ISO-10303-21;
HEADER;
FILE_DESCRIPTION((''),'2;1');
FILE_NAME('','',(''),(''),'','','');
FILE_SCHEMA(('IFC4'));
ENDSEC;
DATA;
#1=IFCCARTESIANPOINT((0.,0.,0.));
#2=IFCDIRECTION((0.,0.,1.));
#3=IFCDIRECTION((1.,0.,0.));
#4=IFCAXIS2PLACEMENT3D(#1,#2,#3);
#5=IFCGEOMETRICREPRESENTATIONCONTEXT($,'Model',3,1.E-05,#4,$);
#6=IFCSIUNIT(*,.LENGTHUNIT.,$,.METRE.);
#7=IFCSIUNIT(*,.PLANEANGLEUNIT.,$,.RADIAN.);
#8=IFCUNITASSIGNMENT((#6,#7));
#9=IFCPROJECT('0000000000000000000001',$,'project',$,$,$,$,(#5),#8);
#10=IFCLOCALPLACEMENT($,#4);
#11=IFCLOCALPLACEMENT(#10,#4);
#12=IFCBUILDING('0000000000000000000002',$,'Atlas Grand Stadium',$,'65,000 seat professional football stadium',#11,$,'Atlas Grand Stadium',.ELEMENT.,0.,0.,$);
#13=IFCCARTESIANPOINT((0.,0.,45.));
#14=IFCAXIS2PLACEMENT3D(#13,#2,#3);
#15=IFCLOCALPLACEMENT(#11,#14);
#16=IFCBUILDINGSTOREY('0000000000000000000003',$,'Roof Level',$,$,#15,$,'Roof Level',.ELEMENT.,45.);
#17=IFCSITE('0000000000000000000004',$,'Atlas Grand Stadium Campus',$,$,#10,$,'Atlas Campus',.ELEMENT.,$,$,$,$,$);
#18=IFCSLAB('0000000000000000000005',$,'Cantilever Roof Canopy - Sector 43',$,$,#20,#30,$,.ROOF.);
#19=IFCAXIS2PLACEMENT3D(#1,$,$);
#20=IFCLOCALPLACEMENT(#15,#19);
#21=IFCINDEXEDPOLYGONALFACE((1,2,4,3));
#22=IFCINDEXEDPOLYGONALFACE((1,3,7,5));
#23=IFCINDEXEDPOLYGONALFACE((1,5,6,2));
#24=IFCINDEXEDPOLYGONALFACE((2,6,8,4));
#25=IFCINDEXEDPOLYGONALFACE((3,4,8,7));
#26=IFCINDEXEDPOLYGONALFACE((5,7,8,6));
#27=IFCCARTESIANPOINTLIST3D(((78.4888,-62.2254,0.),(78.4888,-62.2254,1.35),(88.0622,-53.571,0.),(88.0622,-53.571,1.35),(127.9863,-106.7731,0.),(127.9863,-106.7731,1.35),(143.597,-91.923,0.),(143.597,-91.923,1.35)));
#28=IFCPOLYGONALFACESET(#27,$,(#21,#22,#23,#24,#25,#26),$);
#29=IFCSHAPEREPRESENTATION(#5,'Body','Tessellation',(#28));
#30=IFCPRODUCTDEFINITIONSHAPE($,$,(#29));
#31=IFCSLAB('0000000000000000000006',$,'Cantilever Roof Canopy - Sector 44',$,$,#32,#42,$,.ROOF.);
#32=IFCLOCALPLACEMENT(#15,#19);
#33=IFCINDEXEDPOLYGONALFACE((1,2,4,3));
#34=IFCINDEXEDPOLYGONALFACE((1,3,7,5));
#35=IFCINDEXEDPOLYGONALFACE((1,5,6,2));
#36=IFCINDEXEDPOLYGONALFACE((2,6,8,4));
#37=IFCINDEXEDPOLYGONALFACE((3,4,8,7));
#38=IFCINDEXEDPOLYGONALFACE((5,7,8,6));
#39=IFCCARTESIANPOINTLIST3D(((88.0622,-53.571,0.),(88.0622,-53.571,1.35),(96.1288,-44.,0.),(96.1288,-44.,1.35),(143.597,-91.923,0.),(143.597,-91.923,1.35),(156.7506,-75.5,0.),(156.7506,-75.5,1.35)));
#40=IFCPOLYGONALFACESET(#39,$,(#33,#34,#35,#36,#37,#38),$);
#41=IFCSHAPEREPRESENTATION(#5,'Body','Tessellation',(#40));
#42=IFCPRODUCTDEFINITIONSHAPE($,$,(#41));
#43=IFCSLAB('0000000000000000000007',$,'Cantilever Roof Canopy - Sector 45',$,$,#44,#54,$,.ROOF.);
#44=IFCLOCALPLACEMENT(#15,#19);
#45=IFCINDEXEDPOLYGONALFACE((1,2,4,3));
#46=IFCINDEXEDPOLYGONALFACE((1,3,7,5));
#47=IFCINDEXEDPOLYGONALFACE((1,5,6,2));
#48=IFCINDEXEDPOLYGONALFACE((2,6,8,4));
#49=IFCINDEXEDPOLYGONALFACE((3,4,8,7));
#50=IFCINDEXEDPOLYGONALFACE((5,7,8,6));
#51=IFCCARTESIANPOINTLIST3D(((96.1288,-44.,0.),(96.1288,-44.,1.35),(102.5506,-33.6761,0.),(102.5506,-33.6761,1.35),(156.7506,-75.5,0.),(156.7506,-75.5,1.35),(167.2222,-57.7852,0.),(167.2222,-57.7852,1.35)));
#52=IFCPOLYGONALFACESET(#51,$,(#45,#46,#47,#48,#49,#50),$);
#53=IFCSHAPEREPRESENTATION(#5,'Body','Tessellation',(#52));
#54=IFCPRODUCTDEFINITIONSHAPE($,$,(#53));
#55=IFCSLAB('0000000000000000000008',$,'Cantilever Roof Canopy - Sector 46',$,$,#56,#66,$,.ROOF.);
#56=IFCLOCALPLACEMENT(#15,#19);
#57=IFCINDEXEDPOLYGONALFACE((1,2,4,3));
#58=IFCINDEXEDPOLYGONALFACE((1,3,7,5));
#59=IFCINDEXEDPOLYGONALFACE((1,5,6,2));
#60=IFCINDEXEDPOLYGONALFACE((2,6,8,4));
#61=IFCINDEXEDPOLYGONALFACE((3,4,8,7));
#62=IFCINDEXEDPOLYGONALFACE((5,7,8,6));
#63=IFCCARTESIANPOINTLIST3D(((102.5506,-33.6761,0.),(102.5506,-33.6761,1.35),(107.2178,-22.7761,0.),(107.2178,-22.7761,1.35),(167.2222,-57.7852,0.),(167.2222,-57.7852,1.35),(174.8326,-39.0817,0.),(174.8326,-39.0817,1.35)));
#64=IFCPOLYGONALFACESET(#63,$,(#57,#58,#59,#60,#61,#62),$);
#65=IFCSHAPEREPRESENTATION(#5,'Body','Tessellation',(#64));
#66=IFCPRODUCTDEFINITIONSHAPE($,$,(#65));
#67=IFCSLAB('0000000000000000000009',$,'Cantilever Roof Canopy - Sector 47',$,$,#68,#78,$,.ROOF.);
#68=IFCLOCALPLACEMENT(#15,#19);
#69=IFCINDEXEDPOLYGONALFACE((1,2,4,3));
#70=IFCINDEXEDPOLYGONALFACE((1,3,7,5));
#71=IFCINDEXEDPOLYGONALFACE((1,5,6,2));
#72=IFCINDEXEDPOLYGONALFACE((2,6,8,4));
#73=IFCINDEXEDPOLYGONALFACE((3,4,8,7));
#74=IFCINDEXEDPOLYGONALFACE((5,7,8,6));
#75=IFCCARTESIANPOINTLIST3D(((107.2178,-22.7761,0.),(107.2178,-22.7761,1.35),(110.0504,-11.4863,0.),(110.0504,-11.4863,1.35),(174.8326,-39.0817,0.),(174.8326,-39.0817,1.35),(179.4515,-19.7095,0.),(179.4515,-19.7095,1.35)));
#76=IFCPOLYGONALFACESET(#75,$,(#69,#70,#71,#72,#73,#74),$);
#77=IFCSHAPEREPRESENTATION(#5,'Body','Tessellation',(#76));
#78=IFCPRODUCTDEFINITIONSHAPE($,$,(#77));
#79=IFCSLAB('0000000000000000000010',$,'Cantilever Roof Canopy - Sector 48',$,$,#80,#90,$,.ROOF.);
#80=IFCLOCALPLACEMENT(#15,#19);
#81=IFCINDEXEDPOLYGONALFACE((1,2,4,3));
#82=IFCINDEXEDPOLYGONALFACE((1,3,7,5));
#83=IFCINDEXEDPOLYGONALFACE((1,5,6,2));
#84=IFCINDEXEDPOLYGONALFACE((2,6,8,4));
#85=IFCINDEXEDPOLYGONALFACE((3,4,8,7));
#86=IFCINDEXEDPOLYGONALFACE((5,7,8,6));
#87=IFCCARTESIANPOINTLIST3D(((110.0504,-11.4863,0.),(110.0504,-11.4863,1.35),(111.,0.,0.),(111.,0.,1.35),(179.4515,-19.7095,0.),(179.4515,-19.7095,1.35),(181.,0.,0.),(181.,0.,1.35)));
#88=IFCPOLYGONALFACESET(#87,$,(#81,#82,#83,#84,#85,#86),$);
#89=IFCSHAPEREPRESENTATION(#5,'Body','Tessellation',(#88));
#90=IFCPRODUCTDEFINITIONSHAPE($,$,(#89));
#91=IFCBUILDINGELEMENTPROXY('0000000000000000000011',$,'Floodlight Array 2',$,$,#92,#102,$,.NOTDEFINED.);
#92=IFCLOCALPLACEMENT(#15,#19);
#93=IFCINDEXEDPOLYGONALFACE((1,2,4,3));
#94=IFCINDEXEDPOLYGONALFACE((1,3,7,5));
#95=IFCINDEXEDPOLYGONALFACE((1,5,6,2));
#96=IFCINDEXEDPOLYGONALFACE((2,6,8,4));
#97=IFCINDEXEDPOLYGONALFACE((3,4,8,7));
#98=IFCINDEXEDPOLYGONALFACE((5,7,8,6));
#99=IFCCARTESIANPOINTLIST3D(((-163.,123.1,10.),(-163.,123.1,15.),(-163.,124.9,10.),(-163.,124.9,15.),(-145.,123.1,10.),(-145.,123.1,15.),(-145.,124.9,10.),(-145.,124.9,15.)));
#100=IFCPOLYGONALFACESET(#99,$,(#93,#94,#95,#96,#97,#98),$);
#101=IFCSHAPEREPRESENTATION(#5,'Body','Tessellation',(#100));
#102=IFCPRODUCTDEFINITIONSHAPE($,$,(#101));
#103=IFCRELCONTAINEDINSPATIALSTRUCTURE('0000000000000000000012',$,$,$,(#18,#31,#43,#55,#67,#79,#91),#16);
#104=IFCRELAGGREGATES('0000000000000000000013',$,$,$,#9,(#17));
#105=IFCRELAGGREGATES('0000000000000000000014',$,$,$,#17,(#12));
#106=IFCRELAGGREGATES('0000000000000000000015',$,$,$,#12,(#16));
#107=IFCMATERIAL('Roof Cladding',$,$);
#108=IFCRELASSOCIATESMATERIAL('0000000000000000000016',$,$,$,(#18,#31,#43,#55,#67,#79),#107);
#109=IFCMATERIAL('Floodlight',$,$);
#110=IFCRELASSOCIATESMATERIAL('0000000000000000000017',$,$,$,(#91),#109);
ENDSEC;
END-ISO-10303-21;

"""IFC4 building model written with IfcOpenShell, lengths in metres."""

from ifc_helpers import new_model, si_unit, frame, origin_with_axes, origin_2d_with_axis, place, context, project, spatial, polyline, rectangle, outline, extrude, material, element, save


model = new_model("IFC4")

# Units and contexts
model_context = context("Model", 3, precision=1e-05, world=origin_with_axes())
ifc_project = project(units=[si_unit("LENGTHUNIT", "METRE"), si_unit("PLANEANGLEUNIT", "RADIAN")], contexts=[model_context])

# Site, building, storey
site_placement = place(None, origin_with_axes())
site = spatial("IfcSite", under=ifc_project, at=site_placement, Name="Atlas Grand Stadium Campus", LongName="Atlas Campus", CompositionType="ELEMENT")
building_placement = place(site_placement, origin_with_axes())
building = spatial("IfcBuilding", under=site, at=building_placement, Name="Atlas Grand Stadium", ObjectType="65,000 seat professional football stadium", LongName="Atlas Grand Stadium", CompositionType="ELEMENT", ElevationOfRefHeight=0.0, ElevationOfTerrain=0.0)
storey_placement = place(building_placement, frame((0.0, 0.0, 45.0), z_axis=(0.0, 0.0, 1.0), x_axis=(1.0, 0.0, 0.0)))
storey = spatial("IfcBuildingStorey", under=building, at=storey_placement, Name="Roof Level", LongName="Roof Level", CompositionType="ELEMENT", Elevation=45.0)

# Slabs
ifc_material_1 = material(Name="Roof Cladding")
slab_1_placement = place(storey_placement, origin_with_axes())
element("IfcSlab", 1, at=slab_1_placement, inside=storey, material=ifc_material_1, Name="Cantilever Roof Canopy - Sector 43", PredefinedType="ROOF", context=model_context, shape_type="SweptSolid", body=[
    extrude(outline(polyline([(127.9863, -106.7731), (143.5969, -91.923), (88.0622, -53.571), (78.4888, -62.2254), (127.9863, -106.7731)])), origin_with_axes(), (0.0, 0.0, 1.0), 1.35),
])
slab_2_placement = place(storey_placement, origin_with_axes())
element("IfcSlab", 2, at=slab_2_placement, inside=storey, material=ifc_material_1, Name="Cantilever Roof Canopy - Sector 44", PredefinedType="ROOF", context=model_context, shape_type="SweptSolid", body=[
    extrude(outline(polyline([(143.5969, -91.923), (156.7506, -75.5), (96.1288, -44.0), (88.0622, -53.571), (143.5969, -91.923)])), origin_with_axes(), (0.0, 0.0, 1.0), 1.35),
])
slab_3_placement = place(storey_placement, origin_with_axes())
element("IfcSlab", 3, at=slab_3_placement, inside=storey, material=ifc_material_1, Name="Cantilever Roof Canopy - Sector 45", PredefinedType="ROOF", context=model_context, shape_type="SweptSolid", body=[
    extrude(outline(polyline([(156.7506, -75.5), (167.2222, -57.7852), (102.5506, -33.6761), (96.1288, -44.0), (156.7506, -75.5)])), origin_with_axes(), (0.0, 0.0, 1.0), 1.35),
])
slab_4_placement = place(storey_placement, origin_with_axes())
element("IfcSlab", 4, at=slab_4_placement, inside=storey, material=ifc_material_1, Name="Cantilever Roof Canopy - Sector 46", PredefinedType="ROOF", context=model_context, shape_type="SweptSolid", body=[
    extrude(outline(polyline([(167.2222, -57.7852), (174.8326, -39.0817), (107.2178, -22.7761), (102.5506, -33.6761), (167.2222, -57.7852)])), origin_with_axes(), (0.0, 0.0, 1.0), 1.35),
])
slab_5_placement = place(storey_placement, origin_with_axes())
element("IfcSlab", 5, at=slab_5_placement, inside=storey, material=ifc_material_1, Name="Cantilever Roof Canopy - Sector 47", PredefinedType="ROOF", context=model_context, shape_type="SweptSolid", body=[
    extrude(outline(polyline([(174.8326, -39.0817), (179.4515, -19.7095), (110.0504, -11.4863), (107.2178, -22.7761), (174.8326, -39.0817)])), origin_with_axes(), (0.0, 0.0, 1.0), 1.35),
])
slab_6_placement = place(storey_placement, origin_with_axes())
element("IfcSlab", 6, at=slab_6_placement, inside=storey, material=ifc_material_1, Name="Cantilever Roof Canopy - Sector 48", PredefinedType="ROOF", context=model_context, shape_type="SweptSolid", body=[
    extrude(outline(polyline([(179.4515, -19.7095), (181.0, 0.0), (111.0, 0.0), (110.0504, -11.4863), (179.4515, -19.7095)])), origin_with_axes(), (0.0, 0.0, 1.0), 1.35),
])

# Building element proxy
ifc_material_2 = material(Name="Floodlight")
proxy_placement = place(storey_placement, frame((-154.0, 124.0, 10.0), z_axis=(0.0, 0.0, 1.0), x_axis=(1.0, 0.0, 0.0)))
element("IfcBuildingElementProxy", 7, at=proxy_placement, inside=storey, material=ifc_material_2, Name="Floodlight Array 2", PredefinedType="NOTDEFINED", context=model_context, shape_type="SweptSolid", body=[
    extrude(rectangle(XDim=18.0, YDim=1.8, at=origin_2d_with_axis()), origin_with_axes(), (0.0, 0.0, 1.0), 5.0),
])

save(model, "model.ifc")
